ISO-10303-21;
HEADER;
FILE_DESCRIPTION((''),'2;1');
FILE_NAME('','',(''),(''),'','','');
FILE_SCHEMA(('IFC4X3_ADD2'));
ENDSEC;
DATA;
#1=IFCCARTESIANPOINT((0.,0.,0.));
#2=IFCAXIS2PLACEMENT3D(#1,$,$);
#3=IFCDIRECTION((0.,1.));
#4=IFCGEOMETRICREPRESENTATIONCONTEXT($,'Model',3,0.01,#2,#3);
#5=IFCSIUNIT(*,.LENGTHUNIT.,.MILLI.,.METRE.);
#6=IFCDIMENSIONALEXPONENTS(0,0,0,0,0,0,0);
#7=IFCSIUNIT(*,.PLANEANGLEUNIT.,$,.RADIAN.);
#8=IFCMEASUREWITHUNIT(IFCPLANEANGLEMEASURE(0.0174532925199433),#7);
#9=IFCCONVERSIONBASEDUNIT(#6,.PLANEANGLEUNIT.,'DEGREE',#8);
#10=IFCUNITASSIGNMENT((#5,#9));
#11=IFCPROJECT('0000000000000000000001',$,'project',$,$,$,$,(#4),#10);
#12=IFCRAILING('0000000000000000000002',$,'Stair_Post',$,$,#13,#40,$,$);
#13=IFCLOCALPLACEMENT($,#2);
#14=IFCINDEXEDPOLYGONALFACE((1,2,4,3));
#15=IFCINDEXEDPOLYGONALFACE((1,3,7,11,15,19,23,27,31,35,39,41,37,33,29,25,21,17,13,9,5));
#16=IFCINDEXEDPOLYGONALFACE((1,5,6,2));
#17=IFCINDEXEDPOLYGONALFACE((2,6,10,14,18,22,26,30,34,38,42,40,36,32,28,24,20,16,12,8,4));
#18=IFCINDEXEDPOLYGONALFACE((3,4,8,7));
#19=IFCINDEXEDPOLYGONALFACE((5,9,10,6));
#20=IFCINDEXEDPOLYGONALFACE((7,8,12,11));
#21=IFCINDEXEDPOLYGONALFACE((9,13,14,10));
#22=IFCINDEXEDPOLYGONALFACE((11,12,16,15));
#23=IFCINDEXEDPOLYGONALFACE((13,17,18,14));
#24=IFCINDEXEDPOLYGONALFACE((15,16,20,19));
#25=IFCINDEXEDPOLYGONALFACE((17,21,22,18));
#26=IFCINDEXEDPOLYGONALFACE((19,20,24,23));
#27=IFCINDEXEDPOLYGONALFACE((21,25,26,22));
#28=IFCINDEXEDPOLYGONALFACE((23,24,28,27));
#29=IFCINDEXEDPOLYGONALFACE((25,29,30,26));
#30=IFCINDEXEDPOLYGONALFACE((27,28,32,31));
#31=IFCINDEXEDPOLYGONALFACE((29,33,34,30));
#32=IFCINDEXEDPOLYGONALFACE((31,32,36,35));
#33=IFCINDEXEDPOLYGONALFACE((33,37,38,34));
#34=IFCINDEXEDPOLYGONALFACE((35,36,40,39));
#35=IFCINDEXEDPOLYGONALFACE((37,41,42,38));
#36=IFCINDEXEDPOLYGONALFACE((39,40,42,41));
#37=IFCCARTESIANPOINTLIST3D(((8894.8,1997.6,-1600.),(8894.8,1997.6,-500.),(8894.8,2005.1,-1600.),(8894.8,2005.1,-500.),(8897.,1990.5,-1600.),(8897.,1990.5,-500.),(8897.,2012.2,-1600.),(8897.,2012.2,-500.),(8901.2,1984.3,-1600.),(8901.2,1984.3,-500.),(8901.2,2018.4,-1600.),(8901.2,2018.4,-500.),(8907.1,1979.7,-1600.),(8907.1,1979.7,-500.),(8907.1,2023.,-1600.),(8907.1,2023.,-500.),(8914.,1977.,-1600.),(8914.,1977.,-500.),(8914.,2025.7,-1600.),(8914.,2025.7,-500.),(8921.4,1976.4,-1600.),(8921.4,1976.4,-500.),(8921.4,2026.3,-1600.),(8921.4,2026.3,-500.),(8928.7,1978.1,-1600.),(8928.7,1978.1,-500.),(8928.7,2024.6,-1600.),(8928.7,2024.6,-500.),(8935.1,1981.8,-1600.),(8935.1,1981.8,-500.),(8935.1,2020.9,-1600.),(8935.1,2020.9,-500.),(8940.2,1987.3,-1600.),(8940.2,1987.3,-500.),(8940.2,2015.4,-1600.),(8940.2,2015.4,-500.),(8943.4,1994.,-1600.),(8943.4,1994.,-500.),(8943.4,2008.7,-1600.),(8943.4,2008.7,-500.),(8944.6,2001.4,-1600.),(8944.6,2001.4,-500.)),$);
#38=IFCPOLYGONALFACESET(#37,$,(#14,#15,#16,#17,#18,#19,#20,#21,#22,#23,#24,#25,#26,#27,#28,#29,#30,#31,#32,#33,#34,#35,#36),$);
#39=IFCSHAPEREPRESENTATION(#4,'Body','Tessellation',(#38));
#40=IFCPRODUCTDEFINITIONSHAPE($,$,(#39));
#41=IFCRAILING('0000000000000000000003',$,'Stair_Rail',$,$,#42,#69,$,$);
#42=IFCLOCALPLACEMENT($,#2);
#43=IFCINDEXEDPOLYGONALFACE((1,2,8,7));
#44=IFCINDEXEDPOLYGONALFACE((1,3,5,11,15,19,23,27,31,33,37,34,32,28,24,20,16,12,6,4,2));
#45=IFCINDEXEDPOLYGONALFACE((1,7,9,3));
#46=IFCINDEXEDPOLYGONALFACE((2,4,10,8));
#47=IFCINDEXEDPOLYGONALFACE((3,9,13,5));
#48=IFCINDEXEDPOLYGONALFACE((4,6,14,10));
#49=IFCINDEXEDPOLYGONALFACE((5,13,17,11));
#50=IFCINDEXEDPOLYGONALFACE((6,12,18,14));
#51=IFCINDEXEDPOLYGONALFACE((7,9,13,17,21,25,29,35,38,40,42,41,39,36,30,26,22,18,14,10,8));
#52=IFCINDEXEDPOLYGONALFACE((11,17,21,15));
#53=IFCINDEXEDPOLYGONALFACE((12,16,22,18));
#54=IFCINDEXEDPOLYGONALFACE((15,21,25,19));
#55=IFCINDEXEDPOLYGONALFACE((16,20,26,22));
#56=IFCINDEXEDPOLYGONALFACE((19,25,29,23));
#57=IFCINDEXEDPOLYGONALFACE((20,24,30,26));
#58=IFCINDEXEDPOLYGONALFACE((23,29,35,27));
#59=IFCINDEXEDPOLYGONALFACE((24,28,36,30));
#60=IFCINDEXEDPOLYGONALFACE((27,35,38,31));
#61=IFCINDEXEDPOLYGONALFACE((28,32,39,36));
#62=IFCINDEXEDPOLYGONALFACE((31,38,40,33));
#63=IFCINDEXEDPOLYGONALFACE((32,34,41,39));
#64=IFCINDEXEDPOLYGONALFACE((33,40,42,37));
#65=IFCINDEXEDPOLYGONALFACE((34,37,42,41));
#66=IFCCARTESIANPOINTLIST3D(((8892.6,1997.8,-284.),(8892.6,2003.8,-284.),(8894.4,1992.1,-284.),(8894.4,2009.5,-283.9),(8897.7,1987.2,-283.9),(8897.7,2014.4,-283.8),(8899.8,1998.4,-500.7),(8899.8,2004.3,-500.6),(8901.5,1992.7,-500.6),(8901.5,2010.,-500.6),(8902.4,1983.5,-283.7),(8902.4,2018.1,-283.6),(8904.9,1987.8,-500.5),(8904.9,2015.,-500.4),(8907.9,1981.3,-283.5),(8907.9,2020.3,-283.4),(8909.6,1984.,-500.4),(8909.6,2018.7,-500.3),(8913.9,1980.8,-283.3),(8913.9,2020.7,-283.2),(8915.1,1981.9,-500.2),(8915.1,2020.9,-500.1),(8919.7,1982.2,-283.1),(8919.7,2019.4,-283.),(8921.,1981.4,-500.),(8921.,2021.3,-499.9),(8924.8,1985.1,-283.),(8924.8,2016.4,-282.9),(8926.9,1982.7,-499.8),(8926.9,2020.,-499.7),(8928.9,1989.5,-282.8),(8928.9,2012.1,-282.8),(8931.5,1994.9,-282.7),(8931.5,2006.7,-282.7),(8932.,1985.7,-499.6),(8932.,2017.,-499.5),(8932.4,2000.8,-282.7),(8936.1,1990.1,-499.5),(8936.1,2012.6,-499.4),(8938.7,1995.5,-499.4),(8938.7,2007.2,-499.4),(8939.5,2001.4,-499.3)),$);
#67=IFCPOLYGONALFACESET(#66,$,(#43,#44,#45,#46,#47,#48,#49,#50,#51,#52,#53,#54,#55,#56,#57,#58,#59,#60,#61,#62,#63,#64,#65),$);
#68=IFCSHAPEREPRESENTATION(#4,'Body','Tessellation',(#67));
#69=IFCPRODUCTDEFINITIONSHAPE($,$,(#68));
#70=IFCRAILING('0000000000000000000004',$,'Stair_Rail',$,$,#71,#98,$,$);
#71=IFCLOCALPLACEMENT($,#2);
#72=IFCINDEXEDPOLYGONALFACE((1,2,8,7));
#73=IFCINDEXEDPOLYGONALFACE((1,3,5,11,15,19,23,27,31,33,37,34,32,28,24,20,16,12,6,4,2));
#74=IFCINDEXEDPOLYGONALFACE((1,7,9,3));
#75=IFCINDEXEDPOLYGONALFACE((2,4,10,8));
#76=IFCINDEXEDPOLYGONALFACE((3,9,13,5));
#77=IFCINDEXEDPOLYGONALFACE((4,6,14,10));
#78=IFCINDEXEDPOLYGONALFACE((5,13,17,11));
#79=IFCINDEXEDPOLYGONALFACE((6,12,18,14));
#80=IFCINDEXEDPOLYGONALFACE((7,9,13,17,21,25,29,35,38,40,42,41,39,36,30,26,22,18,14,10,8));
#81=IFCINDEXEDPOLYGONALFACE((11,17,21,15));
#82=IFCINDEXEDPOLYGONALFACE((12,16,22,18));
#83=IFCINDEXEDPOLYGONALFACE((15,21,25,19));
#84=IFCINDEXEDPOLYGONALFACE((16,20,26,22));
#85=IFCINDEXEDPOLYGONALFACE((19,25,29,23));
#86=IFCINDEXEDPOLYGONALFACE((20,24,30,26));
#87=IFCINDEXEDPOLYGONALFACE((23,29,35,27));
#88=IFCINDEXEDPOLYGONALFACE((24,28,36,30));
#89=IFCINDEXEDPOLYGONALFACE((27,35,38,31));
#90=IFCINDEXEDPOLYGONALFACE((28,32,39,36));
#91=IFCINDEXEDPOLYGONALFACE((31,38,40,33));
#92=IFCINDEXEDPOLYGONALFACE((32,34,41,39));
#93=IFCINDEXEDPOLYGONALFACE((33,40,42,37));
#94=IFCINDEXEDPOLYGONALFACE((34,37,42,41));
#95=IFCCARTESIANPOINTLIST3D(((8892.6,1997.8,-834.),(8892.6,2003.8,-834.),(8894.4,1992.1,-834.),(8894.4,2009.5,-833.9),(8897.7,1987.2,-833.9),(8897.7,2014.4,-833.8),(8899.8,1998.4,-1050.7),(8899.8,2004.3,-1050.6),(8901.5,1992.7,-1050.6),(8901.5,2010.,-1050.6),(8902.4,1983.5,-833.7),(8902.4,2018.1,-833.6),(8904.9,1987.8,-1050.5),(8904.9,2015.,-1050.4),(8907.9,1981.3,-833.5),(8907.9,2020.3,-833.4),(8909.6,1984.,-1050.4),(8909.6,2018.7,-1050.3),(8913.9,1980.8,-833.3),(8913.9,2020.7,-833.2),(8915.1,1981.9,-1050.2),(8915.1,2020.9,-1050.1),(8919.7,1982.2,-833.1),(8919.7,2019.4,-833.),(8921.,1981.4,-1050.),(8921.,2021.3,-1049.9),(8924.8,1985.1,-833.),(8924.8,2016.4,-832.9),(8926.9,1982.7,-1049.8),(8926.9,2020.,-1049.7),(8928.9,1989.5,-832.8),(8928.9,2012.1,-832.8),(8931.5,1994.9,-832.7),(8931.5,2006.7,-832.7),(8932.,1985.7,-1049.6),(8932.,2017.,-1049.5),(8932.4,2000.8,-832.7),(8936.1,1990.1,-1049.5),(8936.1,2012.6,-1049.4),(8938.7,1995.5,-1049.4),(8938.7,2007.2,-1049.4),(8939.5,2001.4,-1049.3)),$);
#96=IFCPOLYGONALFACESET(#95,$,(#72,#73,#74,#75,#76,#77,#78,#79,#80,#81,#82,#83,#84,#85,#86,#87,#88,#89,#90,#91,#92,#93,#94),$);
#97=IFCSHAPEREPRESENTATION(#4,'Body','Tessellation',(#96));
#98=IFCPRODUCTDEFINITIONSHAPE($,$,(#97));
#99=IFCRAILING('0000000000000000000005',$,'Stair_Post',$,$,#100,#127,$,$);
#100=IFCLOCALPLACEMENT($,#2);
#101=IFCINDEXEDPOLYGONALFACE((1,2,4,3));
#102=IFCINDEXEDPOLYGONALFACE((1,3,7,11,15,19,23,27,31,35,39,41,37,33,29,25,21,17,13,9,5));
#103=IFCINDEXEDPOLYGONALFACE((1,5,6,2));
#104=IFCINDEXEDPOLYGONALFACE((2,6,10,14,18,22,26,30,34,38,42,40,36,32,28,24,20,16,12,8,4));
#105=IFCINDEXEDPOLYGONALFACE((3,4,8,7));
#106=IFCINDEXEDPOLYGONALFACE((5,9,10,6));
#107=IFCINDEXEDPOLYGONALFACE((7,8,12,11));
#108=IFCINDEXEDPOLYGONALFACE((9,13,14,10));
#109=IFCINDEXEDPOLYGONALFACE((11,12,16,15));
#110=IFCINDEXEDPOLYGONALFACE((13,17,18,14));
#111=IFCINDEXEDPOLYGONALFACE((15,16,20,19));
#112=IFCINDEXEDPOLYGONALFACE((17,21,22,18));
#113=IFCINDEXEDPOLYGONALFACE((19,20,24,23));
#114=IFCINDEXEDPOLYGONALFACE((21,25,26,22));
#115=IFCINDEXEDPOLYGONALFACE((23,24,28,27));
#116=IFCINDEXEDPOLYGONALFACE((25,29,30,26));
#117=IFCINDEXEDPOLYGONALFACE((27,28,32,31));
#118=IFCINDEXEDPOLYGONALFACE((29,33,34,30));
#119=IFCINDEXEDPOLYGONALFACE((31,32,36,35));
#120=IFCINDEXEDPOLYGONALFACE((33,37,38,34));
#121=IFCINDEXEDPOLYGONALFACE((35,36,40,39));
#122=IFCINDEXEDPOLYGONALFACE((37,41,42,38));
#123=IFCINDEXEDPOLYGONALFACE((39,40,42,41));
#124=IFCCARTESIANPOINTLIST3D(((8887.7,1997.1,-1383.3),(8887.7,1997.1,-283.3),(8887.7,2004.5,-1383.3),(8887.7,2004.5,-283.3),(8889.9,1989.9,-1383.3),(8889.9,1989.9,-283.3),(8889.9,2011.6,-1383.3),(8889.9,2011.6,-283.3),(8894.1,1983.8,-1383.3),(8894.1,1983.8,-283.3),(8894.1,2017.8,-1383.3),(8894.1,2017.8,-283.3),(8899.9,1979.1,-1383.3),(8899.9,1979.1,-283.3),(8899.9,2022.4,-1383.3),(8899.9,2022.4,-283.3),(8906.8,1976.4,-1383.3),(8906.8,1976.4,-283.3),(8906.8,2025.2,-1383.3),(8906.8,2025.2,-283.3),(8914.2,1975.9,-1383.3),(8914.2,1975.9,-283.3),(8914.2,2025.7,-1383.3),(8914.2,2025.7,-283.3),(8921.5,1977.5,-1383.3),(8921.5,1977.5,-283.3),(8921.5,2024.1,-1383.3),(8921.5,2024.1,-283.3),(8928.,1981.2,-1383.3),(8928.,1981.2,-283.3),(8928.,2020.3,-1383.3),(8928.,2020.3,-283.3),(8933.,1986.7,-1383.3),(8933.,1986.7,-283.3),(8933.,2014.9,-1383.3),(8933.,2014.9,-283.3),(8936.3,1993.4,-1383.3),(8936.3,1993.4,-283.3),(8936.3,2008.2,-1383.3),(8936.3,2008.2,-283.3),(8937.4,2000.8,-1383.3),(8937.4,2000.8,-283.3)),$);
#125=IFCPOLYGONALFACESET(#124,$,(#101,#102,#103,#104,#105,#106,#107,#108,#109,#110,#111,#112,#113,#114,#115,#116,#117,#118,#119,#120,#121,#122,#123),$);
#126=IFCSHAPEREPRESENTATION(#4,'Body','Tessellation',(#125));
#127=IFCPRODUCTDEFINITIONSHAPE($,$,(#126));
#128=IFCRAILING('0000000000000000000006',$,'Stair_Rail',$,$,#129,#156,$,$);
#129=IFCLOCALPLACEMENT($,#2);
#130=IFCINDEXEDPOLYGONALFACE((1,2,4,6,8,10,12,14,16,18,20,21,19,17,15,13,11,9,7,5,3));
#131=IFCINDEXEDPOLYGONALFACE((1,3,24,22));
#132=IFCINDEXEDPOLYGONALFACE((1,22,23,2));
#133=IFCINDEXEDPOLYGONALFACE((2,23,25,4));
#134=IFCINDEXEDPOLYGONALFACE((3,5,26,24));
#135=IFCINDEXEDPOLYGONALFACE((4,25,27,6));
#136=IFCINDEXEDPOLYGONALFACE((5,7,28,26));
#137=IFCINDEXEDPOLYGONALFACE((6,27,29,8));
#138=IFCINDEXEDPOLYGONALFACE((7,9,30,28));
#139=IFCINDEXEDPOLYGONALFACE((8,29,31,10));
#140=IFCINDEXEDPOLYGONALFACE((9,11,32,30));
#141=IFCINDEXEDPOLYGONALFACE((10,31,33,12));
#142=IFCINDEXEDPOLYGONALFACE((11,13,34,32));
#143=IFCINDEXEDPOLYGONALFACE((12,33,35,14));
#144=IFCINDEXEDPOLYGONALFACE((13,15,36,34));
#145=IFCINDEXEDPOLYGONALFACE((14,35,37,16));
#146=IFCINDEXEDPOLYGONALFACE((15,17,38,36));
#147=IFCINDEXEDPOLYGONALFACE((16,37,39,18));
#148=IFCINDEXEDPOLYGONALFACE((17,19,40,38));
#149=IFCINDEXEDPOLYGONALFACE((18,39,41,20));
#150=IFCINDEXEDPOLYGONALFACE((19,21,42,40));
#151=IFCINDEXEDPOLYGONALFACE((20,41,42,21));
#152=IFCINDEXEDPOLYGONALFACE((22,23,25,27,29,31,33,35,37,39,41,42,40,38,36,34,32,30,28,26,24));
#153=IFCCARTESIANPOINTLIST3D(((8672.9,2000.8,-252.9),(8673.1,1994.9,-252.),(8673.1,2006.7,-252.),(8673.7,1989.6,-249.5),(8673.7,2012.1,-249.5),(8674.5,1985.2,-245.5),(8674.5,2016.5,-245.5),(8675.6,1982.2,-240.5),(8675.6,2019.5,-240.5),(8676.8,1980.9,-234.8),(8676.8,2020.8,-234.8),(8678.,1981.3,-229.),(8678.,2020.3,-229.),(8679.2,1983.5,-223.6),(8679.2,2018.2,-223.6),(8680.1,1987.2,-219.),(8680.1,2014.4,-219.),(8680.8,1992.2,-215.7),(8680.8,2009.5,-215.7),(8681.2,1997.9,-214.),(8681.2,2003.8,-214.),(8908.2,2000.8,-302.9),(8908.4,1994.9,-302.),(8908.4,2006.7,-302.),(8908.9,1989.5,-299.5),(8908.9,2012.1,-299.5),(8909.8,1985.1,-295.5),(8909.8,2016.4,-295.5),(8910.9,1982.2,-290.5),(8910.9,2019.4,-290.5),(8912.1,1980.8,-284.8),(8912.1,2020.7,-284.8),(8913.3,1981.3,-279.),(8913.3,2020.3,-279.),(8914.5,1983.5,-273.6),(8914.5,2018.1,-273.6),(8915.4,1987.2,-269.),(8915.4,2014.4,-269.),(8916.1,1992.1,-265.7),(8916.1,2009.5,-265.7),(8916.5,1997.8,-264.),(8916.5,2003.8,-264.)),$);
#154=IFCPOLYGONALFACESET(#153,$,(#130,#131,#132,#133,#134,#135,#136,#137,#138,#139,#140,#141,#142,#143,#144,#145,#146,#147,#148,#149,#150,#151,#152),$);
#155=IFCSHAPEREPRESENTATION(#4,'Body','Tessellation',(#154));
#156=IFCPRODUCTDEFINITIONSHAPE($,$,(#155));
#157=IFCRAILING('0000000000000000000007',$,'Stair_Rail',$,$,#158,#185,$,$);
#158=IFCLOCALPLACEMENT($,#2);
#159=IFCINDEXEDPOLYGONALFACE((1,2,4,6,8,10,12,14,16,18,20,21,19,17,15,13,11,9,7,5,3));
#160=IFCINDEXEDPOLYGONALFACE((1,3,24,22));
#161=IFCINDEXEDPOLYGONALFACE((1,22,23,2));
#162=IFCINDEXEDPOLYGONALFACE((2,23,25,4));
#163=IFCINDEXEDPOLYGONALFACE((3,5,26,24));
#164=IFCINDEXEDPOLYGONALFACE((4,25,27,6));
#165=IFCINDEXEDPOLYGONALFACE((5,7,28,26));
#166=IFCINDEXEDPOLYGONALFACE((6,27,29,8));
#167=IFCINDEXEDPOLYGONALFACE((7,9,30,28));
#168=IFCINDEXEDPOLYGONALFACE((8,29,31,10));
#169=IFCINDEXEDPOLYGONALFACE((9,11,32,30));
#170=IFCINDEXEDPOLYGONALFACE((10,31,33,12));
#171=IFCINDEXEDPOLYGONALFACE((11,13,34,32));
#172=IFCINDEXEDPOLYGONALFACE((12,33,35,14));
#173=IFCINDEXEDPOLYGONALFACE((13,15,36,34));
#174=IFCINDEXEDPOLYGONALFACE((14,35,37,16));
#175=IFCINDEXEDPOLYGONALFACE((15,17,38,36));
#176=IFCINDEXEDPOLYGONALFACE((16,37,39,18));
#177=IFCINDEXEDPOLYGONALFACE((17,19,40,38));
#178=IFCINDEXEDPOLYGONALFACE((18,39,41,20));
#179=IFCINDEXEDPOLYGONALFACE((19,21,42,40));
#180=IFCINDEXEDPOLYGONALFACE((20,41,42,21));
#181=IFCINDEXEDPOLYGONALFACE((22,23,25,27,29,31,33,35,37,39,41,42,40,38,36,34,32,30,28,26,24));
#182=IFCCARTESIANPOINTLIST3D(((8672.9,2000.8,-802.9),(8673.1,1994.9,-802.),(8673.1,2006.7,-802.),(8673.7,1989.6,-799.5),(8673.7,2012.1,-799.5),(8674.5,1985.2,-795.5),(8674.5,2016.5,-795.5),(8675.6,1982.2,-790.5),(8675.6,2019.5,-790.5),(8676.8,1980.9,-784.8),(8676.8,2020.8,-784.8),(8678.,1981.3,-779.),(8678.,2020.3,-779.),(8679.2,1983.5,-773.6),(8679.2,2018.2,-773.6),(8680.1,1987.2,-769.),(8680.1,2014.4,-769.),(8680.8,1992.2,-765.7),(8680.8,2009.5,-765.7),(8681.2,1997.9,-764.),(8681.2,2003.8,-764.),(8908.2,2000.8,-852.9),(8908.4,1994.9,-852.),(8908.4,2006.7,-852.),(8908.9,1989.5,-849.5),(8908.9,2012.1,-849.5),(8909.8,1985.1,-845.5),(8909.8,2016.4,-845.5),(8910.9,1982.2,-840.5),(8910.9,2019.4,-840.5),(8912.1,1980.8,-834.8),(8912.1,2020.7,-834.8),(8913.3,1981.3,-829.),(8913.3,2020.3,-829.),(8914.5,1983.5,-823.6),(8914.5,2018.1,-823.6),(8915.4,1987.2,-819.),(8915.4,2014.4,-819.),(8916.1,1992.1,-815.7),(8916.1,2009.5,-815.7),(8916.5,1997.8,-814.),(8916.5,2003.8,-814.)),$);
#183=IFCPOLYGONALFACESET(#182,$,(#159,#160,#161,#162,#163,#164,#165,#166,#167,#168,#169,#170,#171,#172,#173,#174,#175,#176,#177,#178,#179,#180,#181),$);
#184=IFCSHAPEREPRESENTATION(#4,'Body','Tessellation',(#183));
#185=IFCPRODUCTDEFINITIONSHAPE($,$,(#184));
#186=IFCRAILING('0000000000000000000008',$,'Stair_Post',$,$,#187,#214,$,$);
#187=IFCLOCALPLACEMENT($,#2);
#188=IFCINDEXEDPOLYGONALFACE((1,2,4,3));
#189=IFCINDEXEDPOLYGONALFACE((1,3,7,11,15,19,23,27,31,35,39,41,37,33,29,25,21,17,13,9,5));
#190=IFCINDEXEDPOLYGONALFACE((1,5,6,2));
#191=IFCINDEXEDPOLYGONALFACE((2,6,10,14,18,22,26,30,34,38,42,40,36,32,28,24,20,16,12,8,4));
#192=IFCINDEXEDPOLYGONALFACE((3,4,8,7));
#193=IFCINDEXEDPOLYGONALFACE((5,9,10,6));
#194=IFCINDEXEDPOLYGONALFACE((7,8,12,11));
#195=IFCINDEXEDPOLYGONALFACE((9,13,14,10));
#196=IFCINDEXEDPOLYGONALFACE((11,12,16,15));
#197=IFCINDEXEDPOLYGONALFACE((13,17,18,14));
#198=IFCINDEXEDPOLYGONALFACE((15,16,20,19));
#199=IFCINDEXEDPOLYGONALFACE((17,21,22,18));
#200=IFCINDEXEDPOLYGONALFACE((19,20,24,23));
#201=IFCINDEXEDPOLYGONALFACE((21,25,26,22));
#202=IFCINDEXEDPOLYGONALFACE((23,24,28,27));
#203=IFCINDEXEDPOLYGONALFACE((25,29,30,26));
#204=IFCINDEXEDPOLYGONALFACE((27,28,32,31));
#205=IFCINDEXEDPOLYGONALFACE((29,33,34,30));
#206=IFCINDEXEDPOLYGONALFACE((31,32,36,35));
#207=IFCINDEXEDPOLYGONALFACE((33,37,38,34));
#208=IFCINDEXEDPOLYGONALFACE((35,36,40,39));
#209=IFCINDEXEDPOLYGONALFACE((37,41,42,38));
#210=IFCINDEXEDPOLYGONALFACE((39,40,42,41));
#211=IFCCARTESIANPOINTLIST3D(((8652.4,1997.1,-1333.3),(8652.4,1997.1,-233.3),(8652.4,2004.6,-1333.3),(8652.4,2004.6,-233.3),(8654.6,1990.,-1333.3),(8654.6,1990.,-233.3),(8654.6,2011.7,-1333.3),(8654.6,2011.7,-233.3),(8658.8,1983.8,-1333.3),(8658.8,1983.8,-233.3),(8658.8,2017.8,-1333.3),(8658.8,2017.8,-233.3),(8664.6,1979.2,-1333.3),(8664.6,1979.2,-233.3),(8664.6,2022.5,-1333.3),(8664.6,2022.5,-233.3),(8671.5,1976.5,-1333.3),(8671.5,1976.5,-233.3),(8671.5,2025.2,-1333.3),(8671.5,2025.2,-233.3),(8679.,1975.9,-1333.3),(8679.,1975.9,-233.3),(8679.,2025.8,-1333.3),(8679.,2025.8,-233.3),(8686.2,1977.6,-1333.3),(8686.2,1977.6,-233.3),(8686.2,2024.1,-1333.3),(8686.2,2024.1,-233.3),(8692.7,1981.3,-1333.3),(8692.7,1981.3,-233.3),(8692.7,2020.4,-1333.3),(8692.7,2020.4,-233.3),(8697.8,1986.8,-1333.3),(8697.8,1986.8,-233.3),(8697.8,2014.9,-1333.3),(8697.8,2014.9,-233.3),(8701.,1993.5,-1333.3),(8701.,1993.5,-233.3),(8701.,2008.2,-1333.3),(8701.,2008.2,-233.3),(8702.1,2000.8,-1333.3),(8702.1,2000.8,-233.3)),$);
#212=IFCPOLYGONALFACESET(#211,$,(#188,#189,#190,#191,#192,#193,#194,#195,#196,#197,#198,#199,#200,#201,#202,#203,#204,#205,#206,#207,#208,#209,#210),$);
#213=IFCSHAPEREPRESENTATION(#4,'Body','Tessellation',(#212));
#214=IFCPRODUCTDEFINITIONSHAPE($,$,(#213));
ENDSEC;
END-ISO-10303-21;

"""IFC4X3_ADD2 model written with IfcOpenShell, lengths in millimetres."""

from ifc_helpers import new_model, entity, si_unit, converted_unit, direction, frame, origin, context, project, circle, extrude, element, save


model = new_model("IFC4X3_ADD2")

# Units and contexts
model_context = context("Model", 3, precision=0.01, world=origin(), true_north=direction((0.0, 1.0)))
ifc_project = project(units=[si_unit("LENGTHUNIT", "METRE", prefix="MILLI"), converted_unit("PLANEANGLEUNIT", "DEGREE", entity("IfcPlaneAngleMeasure", 0.0174532925199433), si_unit("PLANEANGLEUNIT", "RADIAN"), dimensions=[0, 0, 0, 0, 0, 0, 0])], contexts=[model_context])

# Railings
element("IfcRailing", 1, Name="Stair_Post", context=model_context, shape_type="SweptSolid", body=[
    extrude(circle(Radius=25.0), frame((8919.6, 2001.4, -1600.0)), (0.0, 0.0, 1.0), 1100.0),
])
element("IfcRailing", 2, Name="Stair_Rail", context=model_context, shape_type="SweptSolid", body=[
    entity("IfcSweptDiskSolid", entity("IfcPolyline", [entity("IfcCartesianPoint", [8919.6, 2001.4, -500.0]), entity("IfcCartesianPoint", [8912.4, 2000.8, -283.3])]), 20.0),
])
element("IfcRailing", 3, Name="Stair_Rail", context=model_context, shape_type="SweptSolid", body=[
    entity("IfcSweptDiskSolid", entity("IfcPolyline", [entity("IfcCartesianPoint", [8919.6, 2001.4, -1050.0]), entity("IfcCartesianPoint", [8912.4, 2000.8, -833.3])]), 20.0),
])
element("IfcRailing", 4, Name="Stair_Post", context=model_context, shape_type="SweptSolid", body=[
    extrude(circle(Radius=25.0), frame((8912.4, 2000.8, -1383.3)), (0.0, 0.0, 1.0), 1100.0),
])
element("IfcRailing", 5, Name="Stair_Rail", context=model_context, shape_type="SweptSolid", body=[
    entity("IfcSweptDiskSolid", entity("IfcPolyline", [entity("IfcCartesianPoint", [8912.4, 2000.8, -283.3]), entity("IfcCartesianPoint", [8677.1, 2000.8, -233.3])]), 20.0),
])
element("IfcRailing", 6, Name="Stair_Rail", context=model_context, shape_type="SweptSolid", body=[
    entity("IfcSweptDiskSolid", entity("IfcPolyline", [entity("IfcCartesianPoint", [8912.4, 2000.8, -833.3]), entity("IfcCartesianPoint", [8677.1, 2000.8, -783.3])]), 20.0),
])
element("IfcRailing", 7, Name="Stair_Post", context=model_context, shape_type="SweptSolid", body=[
    extrude(circle(Radius=25.0), frame((8677.1, 2000.8, -1333.3)), (0.0, 0.0, 1.0), 1100.0),
])

save(model, "model.ifc")
